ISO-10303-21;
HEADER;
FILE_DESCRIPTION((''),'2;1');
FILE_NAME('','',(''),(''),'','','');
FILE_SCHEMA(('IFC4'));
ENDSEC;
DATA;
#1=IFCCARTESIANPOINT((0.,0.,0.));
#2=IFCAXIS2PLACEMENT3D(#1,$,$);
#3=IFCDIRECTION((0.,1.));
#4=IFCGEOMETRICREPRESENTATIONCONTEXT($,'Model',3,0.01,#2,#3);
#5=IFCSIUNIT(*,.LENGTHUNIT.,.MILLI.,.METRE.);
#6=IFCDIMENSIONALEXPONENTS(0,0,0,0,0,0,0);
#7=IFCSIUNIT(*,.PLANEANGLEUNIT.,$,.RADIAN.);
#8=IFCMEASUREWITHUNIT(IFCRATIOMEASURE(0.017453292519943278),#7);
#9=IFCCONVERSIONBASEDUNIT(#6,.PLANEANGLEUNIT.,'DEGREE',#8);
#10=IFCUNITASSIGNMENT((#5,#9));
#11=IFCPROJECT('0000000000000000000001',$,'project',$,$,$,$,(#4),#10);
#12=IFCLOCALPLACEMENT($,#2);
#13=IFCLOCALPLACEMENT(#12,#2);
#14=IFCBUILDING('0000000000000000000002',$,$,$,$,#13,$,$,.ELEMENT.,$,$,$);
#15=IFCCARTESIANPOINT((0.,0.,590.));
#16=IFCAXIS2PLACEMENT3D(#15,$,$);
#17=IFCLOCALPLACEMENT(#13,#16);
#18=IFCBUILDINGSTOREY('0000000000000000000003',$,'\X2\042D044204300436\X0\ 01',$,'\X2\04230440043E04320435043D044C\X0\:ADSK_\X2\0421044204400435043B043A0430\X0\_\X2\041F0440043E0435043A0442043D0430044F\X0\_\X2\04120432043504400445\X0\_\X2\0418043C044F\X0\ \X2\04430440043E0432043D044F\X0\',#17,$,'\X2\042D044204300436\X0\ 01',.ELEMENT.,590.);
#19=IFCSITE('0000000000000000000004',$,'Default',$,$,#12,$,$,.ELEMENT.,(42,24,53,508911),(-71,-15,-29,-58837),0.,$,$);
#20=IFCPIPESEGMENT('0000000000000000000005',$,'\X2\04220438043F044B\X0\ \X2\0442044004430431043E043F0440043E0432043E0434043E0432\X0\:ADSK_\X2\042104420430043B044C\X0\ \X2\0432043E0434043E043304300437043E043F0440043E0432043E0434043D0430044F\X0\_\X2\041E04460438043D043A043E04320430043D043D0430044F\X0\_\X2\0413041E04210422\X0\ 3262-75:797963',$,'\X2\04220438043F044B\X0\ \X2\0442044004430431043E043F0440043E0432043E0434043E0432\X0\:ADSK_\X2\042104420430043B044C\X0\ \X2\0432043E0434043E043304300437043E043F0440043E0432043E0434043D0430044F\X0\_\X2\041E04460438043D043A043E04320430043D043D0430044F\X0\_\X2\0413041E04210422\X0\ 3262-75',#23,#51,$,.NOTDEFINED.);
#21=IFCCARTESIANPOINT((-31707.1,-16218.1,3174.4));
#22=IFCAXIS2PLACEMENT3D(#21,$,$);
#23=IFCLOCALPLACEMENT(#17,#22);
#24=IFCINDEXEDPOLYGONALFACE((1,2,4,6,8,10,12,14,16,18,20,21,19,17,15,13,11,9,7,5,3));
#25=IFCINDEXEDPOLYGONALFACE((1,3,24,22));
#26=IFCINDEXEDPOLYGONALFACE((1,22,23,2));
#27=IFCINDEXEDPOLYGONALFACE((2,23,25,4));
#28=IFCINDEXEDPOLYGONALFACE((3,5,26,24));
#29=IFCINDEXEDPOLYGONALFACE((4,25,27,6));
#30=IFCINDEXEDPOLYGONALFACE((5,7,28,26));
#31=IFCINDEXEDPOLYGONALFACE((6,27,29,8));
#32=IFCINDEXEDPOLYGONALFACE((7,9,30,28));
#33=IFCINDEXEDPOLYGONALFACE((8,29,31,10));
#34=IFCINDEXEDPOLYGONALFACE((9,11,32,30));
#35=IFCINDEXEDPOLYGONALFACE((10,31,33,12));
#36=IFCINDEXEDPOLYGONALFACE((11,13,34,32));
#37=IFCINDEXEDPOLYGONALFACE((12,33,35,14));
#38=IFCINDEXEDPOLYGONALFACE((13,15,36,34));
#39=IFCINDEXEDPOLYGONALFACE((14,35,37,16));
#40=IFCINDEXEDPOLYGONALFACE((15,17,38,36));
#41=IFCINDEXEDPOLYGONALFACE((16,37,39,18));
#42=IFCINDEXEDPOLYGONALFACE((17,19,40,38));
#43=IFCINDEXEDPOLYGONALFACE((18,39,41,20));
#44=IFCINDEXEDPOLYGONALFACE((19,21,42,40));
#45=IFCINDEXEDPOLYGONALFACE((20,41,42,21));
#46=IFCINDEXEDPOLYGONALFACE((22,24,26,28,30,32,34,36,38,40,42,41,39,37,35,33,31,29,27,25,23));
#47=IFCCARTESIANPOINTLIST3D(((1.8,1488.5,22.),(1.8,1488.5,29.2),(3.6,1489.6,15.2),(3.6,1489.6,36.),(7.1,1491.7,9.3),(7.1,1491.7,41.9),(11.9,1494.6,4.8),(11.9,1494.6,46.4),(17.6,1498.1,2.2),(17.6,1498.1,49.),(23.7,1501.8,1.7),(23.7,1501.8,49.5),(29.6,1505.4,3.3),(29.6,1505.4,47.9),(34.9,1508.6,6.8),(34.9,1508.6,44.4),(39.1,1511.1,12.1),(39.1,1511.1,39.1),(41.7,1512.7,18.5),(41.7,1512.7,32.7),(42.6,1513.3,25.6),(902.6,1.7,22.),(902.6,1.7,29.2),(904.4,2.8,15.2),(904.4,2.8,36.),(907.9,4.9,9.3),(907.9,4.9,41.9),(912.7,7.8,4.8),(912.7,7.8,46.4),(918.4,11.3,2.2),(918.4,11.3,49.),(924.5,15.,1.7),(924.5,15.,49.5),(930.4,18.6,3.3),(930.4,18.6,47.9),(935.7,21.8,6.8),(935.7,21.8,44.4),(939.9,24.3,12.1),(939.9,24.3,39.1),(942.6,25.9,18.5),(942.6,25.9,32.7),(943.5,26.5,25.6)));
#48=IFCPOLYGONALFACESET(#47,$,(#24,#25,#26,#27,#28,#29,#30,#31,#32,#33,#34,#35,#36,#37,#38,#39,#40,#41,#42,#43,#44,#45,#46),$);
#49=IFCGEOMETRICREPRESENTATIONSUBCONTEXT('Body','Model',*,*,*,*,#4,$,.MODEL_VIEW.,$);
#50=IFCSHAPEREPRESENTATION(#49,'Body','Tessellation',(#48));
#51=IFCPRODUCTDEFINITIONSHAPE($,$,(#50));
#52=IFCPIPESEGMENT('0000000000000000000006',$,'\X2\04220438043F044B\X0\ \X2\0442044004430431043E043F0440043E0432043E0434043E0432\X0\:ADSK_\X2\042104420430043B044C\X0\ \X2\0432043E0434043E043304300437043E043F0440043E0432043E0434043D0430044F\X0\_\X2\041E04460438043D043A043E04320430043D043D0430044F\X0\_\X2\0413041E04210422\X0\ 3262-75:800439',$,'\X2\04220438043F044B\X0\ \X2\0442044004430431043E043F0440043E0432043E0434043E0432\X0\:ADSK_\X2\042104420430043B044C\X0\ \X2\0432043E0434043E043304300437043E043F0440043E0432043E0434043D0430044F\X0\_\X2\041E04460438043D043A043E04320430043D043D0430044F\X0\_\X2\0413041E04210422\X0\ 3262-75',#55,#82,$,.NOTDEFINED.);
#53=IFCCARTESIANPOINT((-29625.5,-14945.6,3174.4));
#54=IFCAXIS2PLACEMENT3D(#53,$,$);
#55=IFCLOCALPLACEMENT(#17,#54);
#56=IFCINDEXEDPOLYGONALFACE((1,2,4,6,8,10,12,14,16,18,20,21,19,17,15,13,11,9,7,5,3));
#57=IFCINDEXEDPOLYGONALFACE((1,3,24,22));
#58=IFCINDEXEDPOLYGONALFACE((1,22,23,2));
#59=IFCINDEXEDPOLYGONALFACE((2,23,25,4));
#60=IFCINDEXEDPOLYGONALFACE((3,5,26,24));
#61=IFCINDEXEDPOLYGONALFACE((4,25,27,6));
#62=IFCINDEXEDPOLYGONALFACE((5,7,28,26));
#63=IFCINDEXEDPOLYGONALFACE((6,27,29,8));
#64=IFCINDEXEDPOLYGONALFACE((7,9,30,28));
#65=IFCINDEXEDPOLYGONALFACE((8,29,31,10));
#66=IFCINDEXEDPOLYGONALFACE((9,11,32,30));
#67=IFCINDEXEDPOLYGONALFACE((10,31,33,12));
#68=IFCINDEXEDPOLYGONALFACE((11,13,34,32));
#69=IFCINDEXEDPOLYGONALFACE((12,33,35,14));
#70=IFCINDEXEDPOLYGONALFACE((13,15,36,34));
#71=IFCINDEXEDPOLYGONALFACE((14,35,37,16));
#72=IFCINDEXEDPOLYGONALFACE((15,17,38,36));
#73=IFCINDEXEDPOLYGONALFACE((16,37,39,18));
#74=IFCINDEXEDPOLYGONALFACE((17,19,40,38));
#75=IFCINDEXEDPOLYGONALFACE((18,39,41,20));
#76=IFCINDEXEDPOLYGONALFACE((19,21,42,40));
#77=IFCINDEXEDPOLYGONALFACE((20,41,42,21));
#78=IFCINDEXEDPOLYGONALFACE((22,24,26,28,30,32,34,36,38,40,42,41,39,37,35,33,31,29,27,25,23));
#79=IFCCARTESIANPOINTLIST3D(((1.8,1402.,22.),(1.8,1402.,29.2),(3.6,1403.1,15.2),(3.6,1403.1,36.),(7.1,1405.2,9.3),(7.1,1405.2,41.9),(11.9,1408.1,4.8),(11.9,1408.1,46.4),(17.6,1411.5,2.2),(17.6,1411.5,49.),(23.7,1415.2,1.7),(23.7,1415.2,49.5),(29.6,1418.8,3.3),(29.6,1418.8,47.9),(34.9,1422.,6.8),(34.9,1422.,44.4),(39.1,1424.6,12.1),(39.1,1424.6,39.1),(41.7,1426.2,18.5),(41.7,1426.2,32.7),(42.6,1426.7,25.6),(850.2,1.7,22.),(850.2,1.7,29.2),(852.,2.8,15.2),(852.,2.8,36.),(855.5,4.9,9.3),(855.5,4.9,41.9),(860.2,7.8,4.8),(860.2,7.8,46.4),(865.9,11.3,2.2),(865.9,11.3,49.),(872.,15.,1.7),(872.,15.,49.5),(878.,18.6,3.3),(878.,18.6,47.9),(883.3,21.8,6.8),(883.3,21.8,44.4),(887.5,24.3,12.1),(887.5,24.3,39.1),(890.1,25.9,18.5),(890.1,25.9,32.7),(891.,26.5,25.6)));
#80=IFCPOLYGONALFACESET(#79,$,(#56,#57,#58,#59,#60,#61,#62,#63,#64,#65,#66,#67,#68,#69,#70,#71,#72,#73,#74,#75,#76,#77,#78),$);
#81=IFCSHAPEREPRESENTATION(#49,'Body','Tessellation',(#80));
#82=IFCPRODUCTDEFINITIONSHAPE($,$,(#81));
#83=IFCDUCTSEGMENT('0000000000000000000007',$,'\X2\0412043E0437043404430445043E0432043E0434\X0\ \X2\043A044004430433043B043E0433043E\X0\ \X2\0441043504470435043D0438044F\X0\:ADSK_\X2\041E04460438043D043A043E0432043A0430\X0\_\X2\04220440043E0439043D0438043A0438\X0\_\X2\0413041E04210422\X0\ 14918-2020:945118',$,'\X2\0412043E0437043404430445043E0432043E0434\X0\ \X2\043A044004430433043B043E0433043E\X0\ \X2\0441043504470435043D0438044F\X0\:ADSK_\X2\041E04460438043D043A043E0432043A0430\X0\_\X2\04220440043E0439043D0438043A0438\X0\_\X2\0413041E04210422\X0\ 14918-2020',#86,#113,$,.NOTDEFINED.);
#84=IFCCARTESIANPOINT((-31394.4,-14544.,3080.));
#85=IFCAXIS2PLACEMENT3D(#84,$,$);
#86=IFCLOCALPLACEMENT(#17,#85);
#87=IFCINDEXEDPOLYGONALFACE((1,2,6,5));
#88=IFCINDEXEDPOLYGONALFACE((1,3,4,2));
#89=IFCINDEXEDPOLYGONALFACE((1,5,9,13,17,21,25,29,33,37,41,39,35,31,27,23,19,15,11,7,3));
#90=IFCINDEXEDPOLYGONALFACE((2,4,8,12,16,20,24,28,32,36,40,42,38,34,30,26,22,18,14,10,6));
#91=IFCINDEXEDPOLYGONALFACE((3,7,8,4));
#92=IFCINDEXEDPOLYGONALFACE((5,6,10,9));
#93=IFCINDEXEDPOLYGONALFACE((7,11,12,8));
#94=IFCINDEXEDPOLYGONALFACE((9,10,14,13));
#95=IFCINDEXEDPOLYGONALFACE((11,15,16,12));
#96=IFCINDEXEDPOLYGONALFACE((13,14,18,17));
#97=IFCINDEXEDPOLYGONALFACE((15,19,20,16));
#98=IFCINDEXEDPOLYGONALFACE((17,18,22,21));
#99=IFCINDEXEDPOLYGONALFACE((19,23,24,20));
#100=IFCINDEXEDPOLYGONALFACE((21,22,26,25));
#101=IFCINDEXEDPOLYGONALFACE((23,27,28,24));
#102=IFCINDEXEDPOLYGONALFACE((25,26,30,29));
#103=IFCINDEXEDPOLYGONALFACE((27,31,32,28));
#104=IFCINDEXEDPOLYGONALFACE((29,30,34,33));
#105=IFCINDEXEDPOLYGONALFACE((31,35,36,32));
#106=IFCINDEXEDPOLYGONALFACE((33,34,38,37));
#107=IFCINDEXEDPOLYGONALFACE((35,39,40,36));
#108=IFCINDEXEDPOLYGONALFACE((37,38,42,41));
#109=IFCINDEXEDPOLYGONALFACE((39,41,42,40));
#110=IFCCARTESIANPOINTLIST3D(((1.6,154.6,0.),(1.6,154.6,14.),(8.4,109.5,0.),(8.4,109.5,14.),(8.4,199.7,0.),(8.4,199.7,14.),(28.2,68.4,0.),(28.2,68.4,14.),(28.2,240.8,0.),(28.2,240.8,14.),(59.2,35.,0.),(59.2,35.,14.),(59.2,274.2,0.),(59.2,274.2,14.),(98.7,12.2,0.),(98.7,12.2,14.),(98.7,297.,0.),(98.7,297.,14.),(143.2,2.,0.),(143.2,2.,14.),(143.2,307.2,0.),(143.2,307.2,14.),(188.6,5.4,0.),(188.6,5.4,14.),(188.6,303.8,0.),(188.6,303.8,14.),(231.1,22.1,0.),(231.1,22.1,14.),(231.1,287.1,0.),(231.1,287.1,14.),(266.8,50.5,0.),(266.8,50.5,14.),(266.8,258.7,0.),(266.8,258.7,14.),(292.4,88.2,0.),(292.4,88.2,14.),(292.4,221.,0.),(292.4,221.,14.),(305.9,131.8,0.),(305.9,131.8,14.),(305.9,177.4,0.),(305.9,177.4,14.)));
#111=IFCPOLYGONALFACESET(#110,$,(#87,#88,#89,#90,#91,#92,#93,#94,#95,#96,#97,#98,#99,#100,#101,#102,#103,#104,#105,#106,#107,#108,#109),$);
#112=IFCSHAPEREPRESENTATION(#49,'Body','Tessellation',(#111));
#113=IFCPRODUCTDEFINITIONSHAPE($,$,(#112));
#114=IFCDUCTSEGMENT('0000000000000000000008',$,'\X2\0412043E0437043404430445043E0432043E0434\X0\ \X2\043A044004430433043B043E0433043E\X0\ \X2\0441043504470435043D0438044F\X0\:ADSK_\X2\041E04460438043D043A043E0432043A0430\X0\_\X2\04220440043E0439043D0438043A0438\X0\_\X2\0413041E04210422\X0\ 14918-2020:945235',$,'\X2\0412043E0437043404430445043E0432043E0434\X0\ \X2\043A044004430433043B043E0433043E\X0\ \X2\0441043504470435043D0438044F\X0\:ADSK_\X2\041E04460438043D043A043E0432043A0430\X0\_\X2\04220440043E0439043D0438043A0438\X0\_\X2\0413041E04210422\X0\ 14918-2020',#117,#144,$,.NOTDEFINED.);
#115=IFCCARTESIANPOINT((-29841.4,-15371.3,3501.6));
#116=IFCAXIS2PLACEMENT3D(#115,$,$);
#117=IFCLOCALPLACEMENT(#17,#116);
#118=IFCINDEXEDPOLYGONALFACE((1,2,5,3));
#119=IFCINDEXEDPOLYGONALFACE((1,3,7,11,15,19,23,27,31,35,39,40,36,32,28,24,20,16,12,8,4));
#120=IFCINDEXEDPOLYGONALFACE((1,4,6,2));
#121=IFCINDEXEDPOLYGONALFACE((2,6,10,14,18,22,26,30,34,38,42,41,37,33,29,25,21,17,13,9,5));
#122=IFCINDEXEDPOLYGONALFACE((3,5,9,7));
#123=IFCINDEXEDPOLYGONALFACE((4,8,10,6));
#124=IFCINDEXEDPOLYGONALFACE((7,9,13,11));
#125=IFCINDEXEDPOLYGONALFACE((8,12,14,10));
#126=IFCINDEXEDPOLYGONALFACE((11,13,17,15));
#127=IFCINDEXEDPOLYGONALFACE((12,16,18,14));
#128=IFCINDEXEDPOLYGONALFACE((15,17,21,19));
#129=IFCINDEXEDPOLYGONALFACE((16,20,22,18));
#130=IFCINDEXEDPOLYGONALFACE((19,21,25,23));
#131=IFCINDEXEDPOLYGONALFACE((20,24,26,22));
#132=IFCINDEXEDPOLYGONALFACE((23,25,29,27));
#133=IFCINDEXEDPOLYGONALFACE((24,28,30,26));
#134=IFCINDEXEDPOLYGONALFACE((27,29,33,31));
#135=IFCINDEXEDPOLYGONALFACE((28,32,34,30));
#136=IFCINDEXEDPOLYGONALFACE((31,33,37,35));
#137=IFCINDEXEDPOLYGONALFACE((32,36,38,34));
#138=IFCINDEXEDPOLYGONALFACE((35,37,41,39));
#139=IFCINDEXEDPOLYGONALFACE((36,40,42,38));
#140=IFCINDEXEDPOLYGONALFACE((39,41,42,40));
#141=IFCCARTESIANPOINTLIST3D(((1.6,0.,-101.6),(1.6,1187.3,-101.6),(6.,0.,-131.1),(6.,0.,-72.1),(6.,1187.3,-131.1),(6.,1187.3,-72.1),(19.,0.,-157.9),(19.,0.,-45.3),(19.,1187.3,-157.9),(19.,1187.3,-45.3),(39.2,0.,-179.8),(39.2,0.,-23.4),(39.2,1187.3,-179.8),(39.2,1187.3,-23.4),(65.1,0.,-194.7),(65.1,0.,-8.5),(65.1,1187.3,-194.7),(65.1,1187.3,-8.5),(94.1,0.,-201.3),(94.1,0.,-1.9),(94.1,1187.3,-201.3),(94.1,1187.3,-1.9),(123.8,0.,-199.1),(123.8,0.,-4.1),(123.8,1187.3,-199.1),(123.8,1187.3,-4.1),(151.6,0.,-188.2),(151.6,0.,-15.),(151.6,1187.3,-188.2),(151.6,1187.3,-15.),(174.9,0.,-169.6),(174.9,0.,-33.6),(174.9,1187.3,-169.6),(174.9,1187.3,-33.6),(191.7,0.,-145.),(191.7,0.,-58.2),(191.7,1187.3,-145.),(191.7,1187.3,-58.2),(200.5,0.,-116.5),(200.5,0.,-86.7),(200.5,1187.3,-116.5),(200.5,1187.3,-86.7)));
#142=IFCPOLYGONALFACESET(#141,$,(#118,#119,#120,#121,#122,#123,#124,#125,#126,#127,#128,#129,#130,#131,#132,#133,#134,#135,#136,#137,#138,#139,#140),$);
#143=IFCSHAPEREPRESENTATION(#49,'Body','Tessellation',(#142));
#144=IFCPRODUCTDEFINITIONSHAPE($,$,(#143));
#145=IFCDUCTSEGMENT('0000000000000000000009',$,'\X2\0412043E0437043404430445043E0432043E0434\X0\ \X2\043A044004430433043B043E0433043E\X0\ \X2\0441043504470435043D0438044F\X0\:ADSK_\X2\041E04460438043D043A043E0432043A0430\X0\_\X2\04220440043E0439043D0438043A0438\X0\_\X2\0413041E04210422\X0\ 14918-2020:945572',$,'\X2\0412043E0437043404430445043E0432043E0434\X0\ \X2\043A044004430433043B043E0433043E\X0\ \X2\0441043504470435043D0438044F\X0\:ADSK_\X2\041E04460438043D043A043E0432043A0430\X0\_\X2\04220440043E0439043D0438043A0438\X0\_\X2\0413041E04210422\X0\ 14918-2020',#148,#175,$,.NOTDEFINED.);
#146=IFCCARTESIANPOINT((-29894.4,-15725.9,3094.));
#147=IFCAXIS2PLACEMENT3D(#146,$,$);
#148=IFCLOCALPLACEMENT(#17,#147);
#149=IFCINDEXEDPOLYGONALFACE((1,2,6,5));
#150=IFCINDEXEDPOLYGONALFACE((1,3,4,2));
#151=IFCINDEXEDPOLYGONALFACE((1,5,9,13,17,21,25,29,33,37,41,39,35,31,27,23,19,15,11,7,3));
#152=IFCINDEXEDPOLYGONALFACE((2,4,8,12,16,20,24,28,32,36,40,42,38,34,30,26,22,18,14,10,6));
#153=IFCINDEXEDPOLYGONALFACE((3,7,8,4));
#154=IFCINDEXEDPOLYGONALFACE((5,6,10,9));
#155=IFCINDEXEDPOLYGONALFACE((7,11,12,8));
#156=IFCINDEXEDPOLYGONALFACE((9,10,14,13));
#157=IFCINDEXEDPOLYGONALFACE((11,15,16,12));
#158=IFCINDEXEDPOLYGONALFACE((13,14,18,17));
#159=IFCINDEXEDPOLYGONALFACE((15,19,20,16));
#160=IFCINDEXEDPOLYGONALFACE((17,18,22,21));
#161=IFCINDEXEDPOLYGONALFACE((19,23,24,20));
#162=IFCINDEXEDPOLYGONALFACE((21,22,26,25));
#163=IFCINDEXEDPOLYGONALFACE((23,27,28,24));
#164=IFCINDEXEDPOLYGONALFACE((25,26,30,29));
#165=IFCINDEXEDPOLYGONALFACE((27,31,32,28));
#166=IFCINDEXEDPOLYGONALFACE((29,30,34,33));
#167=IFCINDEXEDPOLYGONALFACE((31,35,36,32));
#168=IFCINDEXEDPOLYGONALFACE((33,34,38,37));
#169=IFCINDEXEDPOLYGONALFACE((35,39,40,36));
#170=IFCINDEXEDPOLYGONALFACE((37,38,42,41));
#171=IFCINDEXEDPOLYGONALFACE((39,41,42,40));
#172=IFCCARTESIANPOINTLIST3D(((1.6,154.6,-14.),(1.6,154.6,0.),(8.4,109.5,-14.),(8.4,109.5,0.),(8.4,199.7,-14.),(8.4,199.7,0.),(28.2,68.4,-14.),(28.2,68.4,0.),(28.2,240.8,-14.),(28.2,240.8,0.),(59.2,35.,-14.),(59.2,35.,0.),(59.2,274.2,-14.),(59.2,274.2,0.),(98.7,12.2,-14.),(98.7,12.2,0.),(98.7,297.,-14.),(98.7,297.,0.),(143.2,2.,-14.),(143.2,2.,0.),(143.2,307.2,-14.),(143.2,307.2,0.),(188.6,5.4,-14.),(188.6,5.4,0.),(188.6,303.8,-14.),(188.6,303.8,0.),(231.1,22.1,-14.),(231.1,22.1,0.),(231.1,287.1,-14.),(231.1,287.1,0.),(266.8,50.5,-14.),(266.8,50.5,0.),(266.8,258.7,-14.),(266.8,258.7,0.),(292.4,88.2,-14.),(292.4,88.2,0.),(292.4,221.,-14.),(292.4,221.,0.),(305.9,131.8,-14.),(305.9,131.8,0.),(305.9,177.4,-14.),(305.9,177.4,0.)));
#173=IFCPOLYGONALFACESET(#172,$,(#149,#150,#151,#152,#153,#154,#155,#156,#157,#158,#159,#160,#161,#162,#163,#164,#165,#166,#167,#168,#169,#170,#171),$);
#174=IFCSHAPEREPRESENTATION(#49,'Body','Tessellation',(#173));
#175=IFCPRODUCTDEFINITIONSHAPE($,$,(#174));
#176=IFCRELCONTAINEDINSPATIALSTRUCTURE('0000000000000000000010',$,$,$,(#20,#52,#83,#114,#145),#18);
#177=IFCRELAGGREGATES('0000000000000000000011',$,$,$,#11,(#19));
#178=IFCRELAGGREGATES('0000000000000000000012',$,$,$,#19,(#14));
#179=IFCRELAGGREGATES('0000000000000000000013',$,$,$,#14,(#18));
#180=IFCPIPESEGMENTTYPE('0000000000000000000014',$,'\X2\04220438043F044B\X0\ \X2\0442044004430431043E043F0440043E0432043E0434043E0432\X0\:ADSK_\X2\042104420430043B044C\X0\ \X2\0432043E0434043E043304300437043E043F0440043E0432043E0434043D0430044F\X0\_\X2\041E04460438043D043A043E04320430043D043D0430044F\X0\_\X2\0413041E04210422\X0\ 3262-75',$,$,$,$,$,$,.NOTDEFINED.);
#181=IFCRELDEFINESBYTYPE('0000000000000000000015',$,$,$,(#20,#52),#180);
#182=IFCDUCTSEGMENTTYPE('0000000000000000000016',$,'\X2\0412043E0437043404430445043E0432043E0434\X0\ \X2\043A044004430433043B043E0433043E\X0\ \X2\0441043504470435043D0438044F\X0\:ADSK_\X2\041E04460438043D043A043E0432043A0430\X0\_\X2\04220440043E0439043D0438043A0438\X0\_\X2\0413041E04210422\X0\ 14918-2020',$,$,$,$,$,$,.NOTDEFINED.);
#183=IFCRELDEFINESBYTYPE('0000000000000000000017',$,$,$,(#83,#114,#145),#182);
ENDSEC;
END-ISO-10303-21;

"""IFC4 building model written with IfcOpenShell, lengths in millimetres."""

from ifc_helpers import new_model, entity, si_unit, converted_unit, direction, frame, frame_2d, origin, origin_2d_with_axis, place, context, subcontext, project, spatial, circle, extrude, type_object, element, save


model = new_model("IFC4")

# Units and contexts
model_context = context("Model", 3, precision=0.01, world=origin(), true_north=direction((0.0, 1.0)))
body_context = subcontext(model_context, "Body", "Model", "MODEL_VIEW")
ifc_project = project(units=[si_unit("LENGTHUNIT", "METRE", prefix="MILLI"), converted_unit("PLANEANGLEUNIT", "DEGREE", entity("IfcRatioMeasure", 0.017453292519943278), si_unit("PLANEANGLEUNIT", "RADIAN"), dimensions=[0, 0, 0, 0, 0, 0, 0])], contexts=[model_context])

# Site, building, storey
site_placement = place(None, origin())
site = spatial("IfcSite", under=ifc_project, at=site_placement, Name="Default", CompositionType="ELEMENT", RefLatitude=(42, 24, 53, 508911), RefLongitude=(-71, -15, -29, -58837), RefElevation=0.0)
building_placement = place(site_placement, origin())
building = spatial("IfcBuilding", under=site, at=building_placement, CompositionType="ELEMENT")
storey_placement = place(building_placement, frame((0.0, 0.0, 590.0)))
storey = spatial("IfcBuildingStorey", under=building, at=storey_placement, Name="Этаж 01", ObjectType="Уровень:ADSK_Стрелка_Проектная_Вверх_Имя уровня", LongName="Этаж 01", CompositionType="ELEMENT", Elevation=590.0)

# Pipe segments
pipe_segment_type = type_object("IfcPipeSegmentType", Name="Типы трубопроводов:ADSK_Сталь водогазопроводная_Оцинкованная_ГОСТ 3262-75", PredefinedType="NOTDEFINED")
pipe_segment_1_placement = place(storey_placement, frame((-31707.1, -16218.1, 3174.4)))
element("IfcPipeSegment", 1, at=pipe_segment_1_placement, inside=storey, type_object=pipe_segment_type, Name="Типы трубопроводов:ADSK_Сталь водогазопроводная_Оцинкованная_ГОСТ 3262-75:797963", ObjectType="Типы трубопроводов:ADSK_Сталь водогазопроводная_Оцинкованная_ГОСТ 3262-75", PredefinedType="NOTDEFINED", context=body_context, shape_type="SweptSolid", body=[
    extrude(circle(Radius=24.0, at=origin_2d_with_axis()), frame((922.9, 14.0, 25.6), z_axis=(-0.518188, 0.855267, 0.0), x_axis=(0.855267, 0.518188, 0.0)), (0.0, 0.0, 1.0), 1738.4),
])
pipe_segment_2_placement = place(storey_placement, frame((-29625.5, -14945.6, 3174.4)))
element("IfcPipeSegment", 2, at=pipe_segment_2_placement, inside=storey, type_object=pipe_segment_type, Name="Типы трубопроводов:ADSK_Сталь водогазопроводная_Оцинкованная_ГОСТ 3262-75:800439", ObjectType="Типы трубопроводов:ADSK_Сталь водогазопроводная_Оцинкованная_ГОСТ 3262-75", PredefinedType="NOTDEFINED", context=body_context, shape_type="SweptSolid", body=[
    extrude(circle(Radius=24.0, at=origin_2d_with_axis()), frame((870.5, 14.0, 25.6), z_axis=(-0.518188, 0.855267, 0.0), x_axis=(0.855267, 0.518188, 0.0)), (0.0, 0.0, 1.0), 1637.2),
])

# Duct segments
duct_segment_type = type_object("IfcDuctSegmentType", Name="Воздуховод круглого сечения:ADSK_Оцинковка_Тройники_ГОСТ 14918-2020", PredefinedType="NOTDEFINED")
duct_segment_1_placement = place(storey_placement, frame((-31394.4, -14544.0, 3080.0)))
element("IfcDuctSegment", 3, at=duct_segment_1_placement, inside=storey, type_object=duct_segment_type, Name="Воздуховод круглого сечения:ADSK_Оцинковка_Тройники_ГОСТ 14918-2020:945118", ObjectType="Воздуховод круглого сечения:ADSK_Оцинковка_Тройники_ГОСТ 14918-2020", PredefinedType="NOTDEFINED", context=body_context, shape_type="SweptSolid", body=[
    extrude(circle(Radius=153.0, at=origin_2d_with_axis()), frame((154.6, 154.6, 0.0), z_axis=(0.0, 0.0, 1.0), x_axis=(-1.0, 0.0, 0.0)), (0.0, 0.0, 1.0), 14.0),
])
duct_segment_2_placement = place(storey_placement, frame((-29841.4, -15371.3, 3501.6)))
element("IfcDuctSegment", 4, at=duct_segment_2_placement, inside=storey, type_object=duct_segment_type, Name="Воздуховод круглого сечения:ADSK_Оцинковка_Тройники_ГОСТ 14918-2020:945235", ObjectType="Воздуховод круглого сечения:ADSK_Оцинковка_Тройники_ГОСТ 14918-2020", PredefinedType="NOTDEFINED", context=body_context, shape_type="SweptSolid", body=[
    extrude(circle(Radius=100.0, at=frame_2d((0.0, 0.0), x_axis=(1.0, 0.0))), frame((101.6, 0.0, -101.6), z_axis=(0.0, 1.0, 0.0), x_axis=(-1.0, 0.0, 0.0)), (0.0, 0.0, 1.0), 1187.3),
])
duct_segment_3_placement = place(storey_placement, frame((-29894.4, -15725.9, 3094.0)))
element("IfcDuctSegment", 5, at=duct_segment_3_placement, inside=storey, type_object=duct_segment_type, Name="Воздуховод круглого сечения:ADSK_Оцинковка_Тройники_ГОСТ 14918-2020:945572", ObjectType="Воздуховод круглого сечения:ADSK_Оцинковка_Тройники_ГОСТ 14918-2020", PredefinedType="NOTDEFINED", context=body_context, shape_type="SweptSolid", body=[
    extrude(circle(Radius=153.0, at=origin_2d_with_axis()), frame((154.6, 154.6, -14.0), z_axis=(0.0, 0.0, 1.0), x_axis=(-1.0, 0.0, 0.0)), (0.0, 0.0, 1.0), 14.0),
])

save(model, "model.ifc")
